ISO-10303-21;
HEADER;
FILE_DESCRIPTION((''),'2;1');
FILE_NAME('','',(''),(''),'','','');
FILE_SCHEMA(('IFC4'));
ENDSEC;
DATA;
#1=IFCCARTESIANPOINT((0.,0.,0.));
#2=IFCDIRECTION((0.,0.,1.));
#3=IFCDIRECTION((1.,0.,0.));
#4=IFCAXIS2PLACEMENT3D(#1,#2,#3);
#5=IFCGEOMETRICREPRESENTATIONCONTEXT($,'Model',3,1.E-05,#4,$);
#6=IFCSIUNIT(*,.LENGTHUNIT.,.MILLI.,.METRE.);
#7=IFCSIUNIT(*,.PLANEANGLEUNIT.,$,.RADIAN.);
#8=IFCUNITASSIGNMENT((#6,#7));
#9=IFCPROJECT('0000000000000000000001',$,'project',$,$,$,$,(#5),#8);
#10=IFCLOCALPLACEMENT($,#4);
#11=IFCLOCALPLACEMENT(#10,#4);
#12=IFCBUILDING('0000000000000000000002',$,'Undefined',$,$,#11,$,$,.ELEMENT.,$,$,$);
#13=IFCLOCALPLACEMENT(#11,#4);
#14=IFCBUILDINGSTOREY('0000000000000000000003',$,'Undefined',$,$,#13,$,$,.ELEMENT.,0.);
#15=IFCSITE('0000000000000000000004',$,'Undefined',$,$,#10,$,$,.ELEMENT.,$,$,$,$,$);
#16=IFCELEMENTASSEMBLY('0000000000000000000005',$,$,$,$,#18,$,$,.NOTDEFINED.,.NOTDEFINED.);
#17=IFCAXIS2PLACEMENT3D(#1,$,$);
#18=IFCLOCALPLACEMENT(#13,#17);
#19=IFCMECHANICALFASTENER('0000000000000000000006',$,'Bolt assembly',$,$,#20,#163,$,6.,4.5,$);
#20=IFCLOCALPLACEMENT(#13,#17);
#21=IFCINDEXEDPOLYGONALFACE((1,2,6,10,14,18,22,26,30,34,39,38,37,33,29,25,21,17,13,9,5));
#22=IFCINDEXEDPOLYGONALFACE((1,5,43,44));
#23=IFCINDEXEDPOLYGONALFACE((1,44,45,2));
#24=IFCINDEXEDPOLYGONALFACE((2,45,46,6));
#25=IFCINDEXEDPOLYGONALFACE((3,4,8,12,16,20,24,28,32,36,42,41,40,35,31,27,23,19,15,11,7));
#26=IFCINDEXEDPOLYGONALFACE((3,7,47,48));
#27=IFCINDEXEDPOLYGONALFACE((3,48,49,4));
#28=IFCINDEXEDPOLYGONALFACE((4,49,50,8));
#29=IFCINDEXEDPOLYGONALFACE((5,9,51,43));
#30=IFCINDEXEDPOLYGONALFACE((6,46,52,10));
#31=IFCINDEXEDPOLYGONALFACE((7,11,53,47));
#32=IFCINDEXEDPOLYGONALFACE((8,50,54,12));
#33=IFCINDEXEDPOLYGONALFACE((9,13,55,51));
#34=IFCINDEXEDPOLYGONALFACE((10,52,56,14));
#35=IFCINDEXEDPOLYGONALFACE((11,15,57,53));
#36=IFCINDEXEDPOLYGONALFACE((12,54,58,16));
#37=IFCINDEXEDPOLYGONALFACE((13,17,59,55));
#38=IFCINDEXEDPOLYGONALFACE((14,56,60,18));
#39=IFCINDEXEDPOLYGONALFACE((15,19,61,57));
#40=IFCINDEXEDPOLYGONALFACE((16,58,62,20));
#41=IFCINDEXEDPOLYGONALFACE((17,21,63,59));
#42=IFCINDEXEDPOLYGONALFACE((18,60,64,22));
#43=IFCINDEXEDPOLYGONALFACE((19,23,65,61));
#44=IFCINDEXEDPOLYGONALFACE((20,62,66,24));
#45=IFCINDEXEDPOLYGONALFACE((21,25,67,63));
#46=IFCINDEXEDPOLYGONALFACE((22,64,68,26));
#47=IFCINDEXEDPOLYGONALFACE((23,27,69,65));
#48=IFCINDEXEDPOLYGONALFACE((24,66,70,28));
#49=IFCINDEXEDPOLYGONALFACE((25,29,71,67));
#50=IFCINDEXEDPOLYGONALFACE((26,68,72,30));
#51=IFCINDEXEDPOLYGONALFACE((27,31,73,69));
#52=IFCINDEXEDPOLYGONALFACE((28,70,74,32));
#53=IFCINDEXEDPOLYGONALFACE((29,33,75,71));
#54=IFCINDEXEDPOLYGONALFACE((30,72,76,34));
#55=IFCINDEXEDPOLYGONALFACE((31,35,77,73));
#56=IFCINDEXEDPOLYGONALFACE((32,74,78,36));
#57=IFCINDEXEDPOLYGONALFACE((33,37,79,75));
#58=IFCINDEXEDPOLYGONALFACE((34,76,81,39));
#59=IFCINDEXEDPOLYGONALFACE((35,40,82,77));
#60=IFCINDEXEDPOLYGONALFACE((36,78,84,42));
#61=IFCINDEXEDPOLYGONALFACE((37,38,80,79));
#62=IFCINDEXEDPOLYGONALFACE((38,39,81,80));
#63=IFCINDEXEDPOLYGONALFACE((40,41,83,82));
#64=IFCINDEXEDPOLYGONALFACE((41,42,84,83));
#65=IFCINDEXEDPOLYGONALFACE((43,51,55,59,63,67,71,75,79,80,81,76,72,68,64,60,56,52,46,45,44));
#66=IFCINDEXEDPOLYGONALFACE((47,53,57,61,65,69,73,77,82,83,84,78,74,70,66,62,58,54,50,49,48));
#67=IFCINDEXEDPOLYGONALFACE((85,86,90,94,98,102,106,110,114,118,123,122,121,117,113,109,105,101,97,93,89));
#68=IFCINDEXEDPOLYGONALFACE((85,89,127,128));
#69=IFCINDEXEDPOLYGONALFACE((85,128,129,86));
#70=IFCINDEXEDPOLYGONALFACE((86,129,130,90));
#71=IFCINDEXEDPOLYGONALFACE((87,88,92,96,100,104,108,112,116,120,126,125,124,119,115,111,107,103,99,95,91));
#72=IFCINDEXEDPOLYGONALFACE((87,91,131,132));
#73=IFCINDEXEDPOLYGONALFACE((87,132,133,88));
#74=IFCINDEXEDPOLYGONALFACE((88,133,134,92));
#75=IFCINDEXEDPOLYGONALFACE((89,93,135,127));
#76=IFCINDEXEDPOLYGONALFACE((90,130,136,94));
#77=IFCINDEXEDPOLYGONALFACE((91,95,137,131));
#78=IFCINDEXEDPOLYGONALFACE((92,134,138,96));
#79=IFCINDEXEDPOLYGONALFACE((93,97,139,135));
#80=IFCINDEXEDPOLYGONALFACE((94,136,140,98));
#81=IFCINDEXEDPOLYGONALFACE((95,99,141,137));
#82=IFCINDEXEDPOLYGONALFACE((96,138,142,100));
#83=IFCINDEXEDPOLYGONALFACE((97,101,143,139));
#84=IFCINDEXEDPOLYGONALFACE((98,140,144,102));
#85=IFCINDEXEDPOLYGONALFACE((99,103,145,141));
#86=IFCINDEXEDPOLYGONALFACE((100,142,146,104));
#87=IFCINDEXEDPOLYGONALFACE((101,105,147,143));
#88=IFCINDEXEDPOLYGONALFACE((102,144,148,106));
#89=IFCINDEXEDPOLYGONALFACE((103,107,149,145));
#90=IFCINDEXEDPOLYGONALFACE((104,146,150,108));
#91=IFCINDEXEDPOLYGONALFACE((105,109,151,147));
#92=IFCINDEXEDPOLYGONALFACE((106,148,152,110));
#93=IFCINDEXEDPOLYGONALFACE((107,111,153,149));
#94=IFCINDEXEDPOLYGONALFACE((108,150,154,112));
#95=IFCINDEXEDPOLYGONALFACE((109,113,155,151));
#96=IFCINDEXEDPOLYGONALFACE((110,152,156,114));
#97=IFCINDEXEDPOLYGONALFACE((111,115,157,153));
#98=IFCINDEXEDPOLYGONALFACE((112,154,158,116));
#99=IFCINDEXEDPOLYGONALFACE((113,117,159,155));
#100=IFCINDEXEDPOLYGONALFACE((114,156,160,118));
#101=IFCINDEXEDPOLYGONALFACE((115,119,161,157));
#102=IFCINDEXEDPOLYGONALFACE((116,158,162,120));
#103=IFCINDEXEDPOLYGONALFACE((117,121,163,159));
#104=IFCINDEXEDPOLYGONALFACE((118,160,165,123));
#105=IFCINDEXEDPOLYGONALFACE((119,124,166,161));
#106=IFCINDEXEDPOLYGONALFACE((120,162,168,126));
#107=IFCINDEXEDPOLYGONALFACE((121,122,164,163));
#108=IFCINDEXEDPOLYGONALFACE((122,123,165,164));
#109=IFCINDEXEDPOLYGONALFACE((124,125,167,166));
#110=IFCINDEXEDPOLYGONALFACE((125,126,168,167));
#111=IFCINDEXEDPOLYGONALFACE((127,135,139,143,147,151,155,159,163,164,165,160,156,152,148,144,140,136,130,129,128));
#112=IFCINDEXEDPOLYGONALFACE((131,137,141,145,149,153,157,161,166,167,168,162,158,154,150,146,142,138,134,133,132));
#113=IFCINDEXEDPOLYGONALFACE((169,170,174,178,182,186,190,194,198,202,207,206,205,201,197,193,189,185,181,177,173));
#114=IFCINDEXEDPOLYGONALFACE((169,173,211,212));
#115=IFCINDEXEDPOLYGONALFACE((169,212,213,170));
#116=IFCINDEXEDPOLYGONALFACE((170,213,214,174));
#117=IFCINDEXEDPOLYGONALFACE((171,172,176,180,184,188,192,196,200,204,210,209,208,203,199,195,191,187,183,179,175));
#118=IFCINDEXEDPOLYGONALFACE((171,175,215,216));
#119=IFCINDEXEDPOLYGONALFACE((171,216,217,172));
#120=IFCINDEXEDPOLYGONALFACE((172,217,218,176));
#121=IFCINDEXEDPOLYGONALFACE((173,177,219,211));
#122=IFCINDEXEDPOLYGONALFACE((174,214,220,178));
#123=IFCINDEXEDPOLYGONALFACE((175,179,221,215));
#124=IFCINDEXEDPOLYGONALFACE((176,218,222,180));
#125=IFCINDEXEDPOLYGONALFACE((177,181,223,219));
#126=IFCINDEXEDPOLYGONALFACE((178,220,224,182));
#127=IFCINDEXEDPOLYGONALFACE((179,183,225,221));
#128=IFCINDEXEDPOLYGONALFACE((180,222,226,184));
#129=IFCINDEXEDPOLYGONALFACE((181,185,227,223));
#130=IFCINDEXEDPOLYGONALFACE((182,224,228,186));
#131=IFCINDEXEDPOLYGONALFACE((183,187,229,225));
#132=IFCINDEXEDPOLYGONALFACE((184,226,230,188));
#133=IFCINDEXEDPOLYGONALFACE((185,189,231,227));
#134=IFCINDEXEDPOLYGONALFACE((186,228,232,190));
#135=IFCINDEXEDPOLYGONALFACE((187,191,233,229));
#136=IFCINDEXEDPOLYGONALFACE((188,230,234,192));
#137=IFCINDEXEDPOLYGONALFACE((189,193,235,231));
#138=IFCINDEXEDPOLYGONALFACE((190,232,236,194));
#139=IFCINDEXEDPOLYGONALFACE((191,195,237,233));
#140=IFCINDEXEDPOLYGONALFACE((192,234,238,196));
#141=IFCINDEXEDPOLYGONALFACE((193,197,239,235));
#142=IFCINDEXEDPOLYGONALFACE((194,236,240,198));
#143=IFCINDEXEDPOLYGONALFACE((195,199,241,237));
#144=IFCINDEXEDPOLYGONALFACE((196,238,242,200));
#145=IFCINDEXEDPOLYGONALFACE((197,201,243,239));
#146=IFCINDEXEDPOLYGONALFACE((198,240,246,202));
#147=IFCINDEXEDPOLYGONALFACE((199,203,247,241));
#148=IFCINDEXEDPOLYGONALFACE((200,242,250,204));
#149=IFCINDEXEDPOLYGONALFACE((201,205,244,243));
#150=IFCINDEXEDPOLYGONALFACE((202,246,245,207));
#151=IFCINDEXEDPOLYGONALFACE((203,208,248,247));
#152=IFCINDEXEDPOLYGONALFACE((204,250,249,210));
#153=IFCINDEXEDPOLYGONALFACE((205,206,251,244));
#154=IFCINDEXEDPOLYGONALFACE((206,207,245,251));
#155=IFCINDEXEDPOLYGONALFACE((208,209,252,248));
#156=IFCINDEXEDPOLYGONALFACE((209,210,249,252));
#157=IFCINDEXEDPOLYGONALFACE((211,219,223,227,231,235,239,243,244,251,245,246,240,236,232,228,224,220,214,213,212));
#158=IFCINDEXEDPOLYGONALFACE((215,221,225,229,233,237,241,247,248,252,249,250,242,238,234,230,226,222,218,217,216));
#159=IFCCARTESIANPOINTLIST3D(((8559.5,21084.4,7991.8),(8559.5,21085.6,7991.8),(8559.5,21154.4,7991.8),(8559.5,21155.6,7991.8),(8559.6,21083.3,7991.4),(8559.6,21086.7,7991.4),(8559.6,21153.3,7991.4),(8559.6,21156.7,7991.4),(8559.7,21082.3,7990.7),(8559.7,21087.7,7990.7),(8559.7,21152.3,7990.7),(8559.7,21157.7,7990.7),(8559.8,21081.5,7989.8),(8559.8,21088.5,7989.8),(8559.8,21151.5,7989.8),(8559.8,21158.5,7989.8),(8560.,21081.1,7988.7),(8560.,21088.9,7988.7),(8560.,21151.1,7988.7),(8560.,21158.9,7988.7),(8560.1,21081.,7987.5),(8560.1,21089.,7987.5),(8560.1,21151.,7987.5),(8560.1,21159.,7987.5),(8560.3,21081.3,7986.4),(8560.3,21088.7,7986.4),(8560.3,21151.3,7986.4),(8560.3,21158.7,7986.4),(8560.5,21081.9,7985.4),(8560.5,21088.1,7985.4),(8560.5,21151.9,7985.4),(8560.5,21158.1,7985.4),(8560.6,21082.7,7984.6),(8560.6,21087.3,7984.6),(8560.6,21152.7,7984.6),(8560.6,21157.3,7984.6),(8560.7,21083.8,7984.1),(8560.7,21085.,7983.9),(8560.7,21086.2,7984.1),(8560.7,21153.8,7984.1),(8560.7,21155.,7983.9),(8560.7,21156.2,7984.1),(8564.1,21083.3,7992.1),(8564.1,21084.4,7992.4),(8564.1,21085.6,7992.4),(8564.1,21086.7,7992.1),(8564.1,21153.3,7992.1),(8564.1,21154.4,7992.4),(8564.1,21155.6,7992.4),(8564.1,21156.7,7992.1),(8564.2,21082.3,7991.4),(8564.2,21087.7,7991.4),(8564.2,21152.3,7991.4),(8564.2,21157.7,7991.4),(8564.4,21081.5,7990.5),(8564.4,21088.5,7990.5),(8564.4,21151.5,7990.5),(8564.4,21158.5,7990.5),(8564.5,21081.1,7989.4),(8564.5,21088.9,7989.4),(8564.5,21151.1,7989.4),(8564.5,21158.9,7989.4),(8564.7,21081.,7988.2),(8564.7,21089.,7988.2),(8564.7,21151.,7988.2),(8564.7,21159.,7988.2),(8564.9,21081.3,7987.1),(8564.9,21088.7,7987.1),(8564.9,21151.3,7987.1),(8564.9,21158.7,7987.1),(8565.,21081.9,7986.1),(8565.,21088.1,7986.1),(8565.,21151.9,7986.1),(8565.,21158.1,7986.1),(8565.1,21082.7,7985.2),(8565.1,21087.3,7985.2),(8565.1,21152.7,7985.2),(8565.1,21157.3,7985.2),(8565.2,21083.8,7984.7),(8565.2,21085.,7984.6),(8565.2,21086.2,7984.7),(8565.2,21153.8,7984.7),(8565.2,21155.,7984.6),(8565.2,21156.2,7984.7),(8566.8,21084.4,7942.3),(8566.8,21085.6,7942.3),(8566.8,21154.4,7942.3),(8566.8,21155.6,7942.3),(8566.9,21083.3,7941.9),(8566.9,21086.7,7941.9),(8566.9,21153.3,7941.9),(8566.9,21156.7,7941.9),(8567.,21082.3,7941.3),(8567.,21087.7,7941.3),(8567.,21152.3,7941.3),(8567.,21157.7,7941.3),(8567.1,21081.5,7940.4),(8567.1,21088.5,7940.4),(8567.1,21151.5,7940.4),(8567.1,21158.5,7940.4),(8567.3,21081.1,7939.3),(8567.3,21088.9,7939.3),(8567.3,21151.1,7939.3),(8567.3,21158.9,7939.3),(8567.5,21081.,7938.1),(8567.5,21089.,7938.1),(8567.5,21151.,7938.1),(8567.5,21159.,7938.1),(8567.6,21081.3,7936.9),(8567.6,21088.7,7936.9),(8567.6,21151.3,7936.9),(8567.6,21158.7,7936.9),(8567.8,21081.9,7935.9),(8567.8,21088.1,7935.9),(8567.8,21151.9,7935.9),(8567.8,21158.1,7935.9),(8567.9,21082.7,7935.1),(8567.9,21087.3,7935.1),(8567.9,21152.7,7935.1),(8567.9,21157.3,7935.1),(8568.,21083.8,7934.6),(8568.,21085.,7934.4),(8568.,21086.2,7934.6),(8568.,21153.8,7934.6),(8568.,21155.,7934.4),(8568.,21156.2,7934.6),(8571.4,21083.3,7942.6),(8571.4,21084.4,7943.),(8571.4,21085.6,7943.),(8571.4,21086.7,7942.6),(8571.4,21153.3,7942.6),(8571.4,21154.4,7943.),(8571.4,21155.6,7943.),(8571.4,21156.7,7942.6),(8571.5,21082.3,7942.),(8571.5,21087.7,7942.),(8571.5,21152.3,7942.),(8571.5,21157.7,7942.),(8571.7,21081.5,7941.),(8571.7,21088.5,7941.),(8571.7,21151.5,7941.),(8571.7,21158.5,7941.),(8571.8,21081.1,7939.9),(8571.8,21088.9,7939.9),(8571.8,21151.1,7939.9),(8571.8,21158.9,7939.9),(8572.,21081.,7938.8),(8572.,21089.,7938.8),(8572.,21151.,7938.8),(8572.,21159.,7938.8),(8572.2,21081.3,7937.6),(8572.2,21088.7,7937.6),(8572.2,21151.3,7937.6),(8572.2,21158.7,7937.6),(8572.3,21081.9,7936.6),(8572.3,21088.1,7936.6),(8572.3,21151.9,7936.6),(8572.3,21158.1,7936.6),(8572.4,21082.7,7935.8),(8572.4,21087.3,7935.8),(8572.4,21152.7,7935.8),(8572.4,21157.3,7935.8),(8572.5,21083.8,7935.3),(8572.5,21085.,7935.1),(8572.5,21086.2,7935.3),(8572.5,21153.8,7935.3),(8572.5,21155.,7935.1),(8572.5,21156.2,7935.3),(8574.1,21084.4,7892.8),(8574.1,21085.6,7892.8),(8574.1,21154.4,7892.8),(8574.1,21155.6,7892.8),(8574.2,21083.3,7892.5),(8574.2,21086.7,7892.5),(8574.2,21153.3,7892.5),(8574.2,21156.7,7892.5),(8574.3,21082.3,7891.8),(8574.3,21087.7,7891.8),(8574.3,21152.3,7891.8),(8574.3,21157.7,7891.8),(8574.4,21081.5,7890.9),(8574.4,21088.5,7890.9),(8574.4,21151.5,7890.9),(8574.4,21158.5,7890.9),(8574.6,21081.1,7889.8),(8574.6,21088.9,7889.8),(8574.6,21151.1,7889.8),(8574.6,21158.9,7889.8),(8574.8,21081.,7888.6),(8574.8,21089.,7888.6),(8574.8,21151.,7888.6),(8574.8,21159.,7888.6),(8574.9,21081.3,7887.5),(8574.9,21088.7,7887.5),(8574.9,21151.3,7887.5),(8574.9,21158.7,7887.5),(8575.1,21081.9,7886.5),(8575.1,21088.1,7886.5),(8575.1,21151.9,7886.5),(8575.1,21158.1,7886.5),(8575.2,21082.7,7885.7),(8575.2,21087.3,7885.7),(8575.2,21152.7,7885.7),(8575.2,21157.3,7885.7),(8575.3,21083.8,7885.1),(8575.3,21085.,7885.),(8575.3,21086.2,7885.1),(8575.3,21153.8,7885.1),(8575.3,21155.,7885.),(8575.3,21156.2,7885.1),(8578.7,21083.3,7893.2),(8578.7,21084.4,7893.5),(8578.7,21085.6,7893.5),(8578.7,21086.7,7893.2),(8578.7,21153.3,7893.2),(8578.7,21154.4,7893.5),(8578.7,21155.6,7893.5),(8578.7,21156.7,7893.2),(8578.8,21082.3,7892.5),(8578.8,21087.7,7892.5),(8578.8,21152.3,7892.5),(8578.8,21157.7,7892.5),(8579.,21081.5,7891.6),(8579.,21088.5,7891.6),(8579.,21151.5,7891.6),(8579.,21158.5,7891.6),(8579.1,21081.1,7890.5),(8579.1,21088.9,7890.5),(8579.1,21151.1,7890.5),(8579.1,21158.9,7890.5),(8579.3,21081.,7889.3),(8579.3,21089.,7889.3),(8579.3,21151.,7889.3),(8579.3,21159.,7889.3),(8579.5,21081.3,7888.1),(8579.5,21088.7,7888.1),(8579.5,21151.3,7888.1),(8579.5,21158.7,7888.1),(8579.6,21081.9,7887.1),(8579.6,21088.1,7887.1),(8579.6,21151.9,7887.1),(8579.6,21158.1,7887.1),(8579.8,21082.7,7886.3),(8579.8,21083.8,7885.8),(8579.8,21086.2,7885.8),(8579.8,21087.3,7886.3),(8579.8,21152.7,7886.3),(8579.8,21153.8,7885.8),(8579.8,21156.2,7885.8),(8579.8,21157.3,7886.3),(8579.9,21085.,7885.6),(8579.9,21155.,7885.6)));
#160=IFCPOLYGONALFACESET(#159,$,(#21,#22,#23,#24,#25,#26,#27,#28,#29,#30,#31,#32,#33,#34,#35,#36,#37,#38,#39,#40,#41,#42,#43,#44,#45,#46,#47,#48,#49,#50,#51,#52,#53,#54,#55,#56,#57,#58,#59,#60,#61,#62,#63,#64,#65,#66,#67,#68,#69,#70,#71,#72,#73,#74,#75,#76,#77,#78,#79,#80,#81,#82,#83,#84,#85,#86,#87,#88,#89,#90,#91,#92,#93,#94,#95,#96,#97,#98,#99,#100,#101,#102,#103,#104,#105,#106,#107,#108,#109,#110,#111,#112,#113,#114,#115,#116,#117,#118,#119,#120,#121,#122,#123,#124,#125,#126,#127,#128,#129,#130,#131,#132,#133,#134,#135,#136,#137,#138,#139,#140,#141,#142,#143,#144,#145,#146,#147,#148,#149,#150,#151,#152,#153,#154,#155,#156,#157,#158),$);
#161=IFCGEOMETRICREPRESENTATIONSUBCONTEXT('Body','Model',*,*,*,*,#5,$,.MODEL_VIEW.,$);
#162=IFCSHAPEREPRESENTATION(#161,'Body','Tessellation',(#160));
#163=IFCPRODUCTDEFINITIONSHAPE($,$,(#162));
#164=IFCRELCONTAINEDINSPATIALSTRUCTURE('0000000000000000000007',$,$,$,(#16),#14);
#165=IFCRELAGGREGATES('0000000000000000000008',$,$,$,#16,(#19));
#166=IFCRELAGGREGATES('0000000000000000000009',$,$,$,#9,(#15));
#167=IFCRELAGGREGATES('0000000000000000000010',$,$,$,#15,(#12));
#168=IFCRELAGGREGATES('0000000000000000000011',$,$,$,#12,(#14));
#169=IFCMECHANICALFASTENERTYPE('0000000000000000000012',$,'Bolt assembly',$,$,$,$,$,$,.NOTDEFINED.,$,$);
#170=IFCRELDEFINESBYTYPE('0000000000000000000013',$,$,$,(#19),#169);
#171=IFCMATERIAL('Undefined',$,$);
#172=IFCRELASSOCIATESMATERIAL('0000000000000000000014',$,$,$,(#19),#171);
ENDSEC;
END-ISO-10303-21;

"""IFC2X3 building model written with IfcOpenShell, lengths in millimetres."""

from ifc_helpers import new_model, si_unit, frame, origin_with_axes, origin_2d_with_axis, place, context, subcontext, project, spatial, circle, extrude, source, transform, mapped, material, type_object, element, aggregate, save


model = new_model("IFC2X3")

# Units and contexts
model_context = context("Model", 3, precision=1e-05, world=origin_with_axes())
body_context = subcontext(model_context, "Body", "Model", "MODEL_VIEW")
ifc_project = project(units=[si_unit("LENGTHUNIT", "METRE", prefix="MILLI"), si_unit("PLANEANGLEUNIT", "RADIAN")], contexts=[model_context])

# Site, building, storey
site_placement = place(None, origin_with_axes())
site = spatial("IfcSite", under=ifc_project, at=site_placement, Name="Undefined", CompositionType="ELEMENT")
building_placement = place(site_placement, origin_with_axes())
building = spatial("IfcBuilding", under=site, at=building_placement, Name="Undefined", CompositionType="ELEMENT")
storey_placement = place(building_placement, origin_with_axes())
storey = spatial("IfcBuildingStorey", under=building, at=storey_placement, Name="Undefined", CompositionType="ELEMENT", Elevation=0.0)

# Element assembly
assembly_1_placement = place(storey_placement, origin_with_axes())
assembly_1 = element("IfcElementAssembly", 1, at=assembly_1_placement, inside=storey, AssemblyPlace="NOTDEFINED", PredefinedType="NOTDEFINED")

# Mechanical fastener
ifc_material_1 = material(Name="Undefined")
mechanical_fastener_type = type_object("IfcMechanicalFastenerType", Name="Bolt assembly")
shared_shape_1 = source(origin_with_axes(), body_context, "Body", "SweptSolid", [
    extrude(circle(Radius=4.0, at=origin_2d_with_axis()), frame((0.0, 0.0, 0.0), z_axis=(0.0, 1.0, 0.0), x_axis=(1.0, 0.0, 0.0)), (0.0, 0.0, 1.0), 4.6),
])
mechanical_fastener_1_placement = place(assembly_1_placement, frame((8560.1, 21120.0, 7987.8), z_axis=(0.0, -1.0, 0.0), x_axis=(0.146203, 0.0, -0.989255)))
mechanical_fastener_1 = element("IfcMechanicalFastener", 2, at=mechanical_fastener_1_placement, type_object=mechanical_fastener_type, material=ifc_material_1, Name="Bolt assembly", NominalDiameter=6.0, NominalLength=4.5, context=body_context, shape_type="MappedRepresentation", body=[
    mapped(shared_shape_1, transform((0.0, 0.0, -35.0))),
    mapped(shared_shape_1, transform((50.0, 0.0, -35.0))),
    mapped(shared_shape_1, transform((100.0, 0.0, -35.0))),
    mapped(shared_shape_1, transform((0.0, 0.0, 35.0))),
    mapped(shared_shape_1, transform((50.0, 0.0, 35.0))),
    mapped(shared_shape_1, transform((100.0, 0.0, 35.0))),
])

aggregate(assembly_1, [mechanical_fastener_1])

save(model, "model.ifc")
